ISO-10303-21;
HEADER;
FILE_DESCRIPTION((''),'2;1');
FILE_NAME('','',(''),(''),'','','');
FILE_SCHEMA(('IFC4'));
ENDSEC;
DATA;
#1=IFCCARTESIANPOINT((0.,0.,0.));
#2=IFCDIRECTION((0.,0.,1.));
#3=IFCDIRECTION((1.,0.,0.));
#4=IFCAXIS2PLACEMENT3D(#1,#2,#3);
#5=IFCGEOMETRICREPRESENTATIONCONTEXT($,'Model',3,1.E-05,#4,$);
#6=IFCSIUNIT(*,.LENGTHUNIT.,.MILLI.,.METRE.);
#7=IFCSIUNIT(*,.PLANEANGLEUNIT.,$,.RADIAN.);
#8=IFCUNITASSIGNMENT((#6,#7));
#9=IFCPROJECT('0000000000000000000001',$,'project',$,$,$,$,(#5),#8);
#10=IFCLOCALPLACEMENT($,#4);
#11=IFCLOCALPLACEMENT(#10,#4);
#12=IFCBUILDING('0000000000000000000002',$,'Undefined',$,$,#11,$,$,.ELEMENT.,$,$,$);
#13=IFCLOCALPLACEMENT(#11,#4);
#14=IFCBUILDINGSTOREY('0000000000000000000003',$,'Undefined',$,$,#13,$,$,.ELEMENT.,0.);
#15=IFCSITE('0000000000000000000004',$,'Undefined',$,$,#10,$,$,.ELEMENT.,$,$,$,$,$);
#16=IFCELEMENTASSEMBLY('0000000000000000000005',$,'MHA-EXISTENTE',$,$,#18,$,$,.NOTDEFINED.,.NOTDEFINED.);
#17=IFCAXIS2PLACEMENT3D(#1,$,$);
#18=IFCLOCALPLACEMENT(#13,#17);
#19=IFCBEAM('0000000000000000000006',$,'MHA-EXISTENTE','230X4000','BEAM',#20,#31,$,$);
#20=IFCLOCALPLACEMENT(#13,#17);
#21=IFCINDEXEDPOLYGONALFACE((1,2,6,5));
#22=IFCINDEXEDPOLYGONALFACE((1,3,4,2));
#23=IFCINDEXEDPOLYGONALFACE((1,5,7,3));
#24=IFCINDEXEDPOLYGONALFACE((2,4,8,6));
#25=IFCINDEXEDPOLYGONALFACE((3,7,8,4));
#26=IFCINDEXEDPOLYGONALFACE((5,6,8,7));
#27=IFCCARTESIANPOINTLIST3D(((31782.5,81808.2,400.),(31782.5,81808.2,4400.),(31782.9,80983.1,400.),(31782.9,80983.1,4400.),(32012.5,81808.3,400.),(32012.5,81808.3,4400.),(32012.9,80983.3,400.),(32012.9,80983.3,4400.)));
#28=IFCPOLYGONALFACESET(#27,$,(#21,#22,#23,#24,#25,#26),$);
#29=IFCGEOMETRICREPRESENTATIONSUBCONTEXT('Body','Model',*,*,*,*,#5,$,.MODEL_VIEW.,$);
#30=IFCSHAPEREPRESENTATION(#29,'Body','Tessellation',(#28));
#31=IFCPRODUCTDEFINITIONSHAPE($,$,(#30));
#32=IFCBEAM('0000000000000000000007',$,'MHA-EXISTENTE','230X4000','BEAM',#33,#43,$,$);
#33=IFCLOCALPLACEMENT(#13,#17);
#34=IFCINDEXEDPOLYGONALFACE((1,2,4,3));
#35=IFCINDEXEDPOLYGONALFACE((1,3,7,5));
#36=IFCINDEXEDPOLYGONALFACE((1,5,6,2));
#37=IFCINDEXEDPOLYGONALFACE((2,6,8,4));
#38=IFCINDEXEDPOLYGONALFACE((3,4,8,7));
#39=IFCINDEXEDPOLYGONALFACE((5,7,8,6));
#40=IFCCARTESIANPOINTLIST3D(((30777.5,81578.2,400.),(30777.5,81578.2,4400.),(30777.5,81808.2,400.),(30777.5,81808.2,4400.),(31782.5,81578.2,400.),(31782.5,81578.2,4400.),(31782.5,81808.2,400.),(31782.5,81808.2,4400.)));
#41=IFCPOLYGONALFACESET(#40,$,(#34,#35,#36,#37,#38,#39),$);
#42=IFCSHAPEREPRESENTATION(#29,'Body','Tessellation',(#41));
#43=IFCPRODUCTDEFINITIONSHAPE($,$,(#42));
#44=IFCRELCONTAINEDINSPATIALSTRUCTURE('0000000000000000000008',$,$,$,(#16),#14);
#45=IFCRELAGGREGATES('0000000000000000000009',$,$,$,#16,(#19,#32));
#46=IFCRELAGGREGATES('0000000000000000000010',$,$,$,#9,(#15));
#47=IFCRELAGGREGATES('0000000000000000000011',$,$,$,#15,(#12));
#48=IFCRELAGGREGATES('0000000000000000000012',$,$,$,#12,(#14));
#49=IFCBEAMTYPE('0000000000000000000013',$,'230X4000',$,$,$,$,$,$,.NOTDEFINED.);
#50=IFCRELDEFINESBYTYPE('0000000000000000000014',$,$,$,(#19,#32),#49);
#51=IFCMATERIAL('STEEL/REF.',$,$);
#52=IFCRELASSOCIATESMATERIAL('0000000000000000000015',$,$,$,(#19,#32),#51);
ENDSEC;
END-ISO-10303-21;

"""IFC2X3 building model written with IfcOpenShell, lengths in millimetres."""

from ifc_helpers import new_model, si_unit, frame, origin_with_axes, origin_2d_with_axis, place, context, subcontext, project, spatial, rectangle, extrude, material, type_object, element, aggregate, save


model = new_model("IFC2X3")

# Units and contexts
model_context = context("Model", 3, precision=1e-05, world=origin_with_axes())
body_context = subcontext(model_context, "Body", "Model", "MODEL_VIEW")
ifc_project = project(units=[si_unit("LENGTHUNIT", "METRE", prefix="MILLI"), si_unit("PLANEANGLEUNIT", "RADIAN")], contexts=[model_context])

# Site, building, storey
site_placement = place(None, origin_with_axes())
site = spatial("IfcSite", under=ifc_project, at=site_placement, Name="Undefined", CompositionType="ELEMENT")
building_placement = place(site_placement, origin_with_axes())
building = spatial("IfcBuilding", under=site, at=building_placement, Name="Undefined", CompositionType="ELEMENT")
storey_placement = place(building_placement, origin_with_axes())
storey = spatial("IfcBuildingStorey", under=building, at=storey_placement, Name="Undefined", CompositionType="ELEMENT", Elevation=0.0)

# Shared definitions
ifc_material_1 = material(Name="STEEL/REF.")

# Element assembly, beams
assembly_1_placement = place(storey_placement, origin_with_axes())
assembly_1 = element("IfcElementAssembly", 1, at=assembly_1_placement, inside=storey, Name="MHA-EXISTENTE", AssemblyPlace="NOTDEFINED", PredefinedType="NOTDEFINED")
beam_type_1 = type_object("IfcBeamType", Name="230X4000", PredefinedType="NOTDEFINED")
beam_1_placement = place(assembly_1_placement, frame((31897.5, 81808.2, 2400.0), z_axis=(1.0, 0.000458, 0.0), x_axis=(0.000458, -1.0, 0.0)))
beam_1 = element("IfcBeam", 2, at=beam_1_placement, type_object=beam_type_1, material=ifc_material_1, Name="MHA-EXISTENTE", Description="230X4000", ObjectType="BEAM", context=body_context, shape_type="SweptSolid", body=[
    extrude(rectangle(XDim=4000.0, YDim=230.0, at=origin_2d_with_axis()), frame((825.0, 0.0, 0.0), z_axis=(-1.0, 0.0, 0.0), x_axis=(0.0, -1.0, 0.0)), (0.0, 0.0, 1.0), 825.0),
])
beam_2_placement = place(assembly_1_placement, frame((30777.5, 81693.2, 2400.0), z_axis=(0.0, 1.0, 0.0), x_axis=(1.0, 0.0, 0.0)))
beam_2 = element("IfcBeam", 3, at=beam_2_placement, type_object=beam_type_1, material=ifc_material_1, Name="MHA-EXISTENTE", Description="230X4000", ObjectType="BEAM", context=body_context, shape_type="SweptSolid", body=[
    extrude(rectangle(XDim=4000.0, YDim=230.0, at=origin_2d_with_axis()), frame((1005.0, 0.0, 0.0), z_axis=(-1.0, 0.0, 0.0), x_axis=(0.0, -1.0, 0.0)), (0.0, 0.0, 1.0), 1005.0),
])
aggregate(assembly_1, [beam_1, beam_2])

save(model, "model.ifc")
